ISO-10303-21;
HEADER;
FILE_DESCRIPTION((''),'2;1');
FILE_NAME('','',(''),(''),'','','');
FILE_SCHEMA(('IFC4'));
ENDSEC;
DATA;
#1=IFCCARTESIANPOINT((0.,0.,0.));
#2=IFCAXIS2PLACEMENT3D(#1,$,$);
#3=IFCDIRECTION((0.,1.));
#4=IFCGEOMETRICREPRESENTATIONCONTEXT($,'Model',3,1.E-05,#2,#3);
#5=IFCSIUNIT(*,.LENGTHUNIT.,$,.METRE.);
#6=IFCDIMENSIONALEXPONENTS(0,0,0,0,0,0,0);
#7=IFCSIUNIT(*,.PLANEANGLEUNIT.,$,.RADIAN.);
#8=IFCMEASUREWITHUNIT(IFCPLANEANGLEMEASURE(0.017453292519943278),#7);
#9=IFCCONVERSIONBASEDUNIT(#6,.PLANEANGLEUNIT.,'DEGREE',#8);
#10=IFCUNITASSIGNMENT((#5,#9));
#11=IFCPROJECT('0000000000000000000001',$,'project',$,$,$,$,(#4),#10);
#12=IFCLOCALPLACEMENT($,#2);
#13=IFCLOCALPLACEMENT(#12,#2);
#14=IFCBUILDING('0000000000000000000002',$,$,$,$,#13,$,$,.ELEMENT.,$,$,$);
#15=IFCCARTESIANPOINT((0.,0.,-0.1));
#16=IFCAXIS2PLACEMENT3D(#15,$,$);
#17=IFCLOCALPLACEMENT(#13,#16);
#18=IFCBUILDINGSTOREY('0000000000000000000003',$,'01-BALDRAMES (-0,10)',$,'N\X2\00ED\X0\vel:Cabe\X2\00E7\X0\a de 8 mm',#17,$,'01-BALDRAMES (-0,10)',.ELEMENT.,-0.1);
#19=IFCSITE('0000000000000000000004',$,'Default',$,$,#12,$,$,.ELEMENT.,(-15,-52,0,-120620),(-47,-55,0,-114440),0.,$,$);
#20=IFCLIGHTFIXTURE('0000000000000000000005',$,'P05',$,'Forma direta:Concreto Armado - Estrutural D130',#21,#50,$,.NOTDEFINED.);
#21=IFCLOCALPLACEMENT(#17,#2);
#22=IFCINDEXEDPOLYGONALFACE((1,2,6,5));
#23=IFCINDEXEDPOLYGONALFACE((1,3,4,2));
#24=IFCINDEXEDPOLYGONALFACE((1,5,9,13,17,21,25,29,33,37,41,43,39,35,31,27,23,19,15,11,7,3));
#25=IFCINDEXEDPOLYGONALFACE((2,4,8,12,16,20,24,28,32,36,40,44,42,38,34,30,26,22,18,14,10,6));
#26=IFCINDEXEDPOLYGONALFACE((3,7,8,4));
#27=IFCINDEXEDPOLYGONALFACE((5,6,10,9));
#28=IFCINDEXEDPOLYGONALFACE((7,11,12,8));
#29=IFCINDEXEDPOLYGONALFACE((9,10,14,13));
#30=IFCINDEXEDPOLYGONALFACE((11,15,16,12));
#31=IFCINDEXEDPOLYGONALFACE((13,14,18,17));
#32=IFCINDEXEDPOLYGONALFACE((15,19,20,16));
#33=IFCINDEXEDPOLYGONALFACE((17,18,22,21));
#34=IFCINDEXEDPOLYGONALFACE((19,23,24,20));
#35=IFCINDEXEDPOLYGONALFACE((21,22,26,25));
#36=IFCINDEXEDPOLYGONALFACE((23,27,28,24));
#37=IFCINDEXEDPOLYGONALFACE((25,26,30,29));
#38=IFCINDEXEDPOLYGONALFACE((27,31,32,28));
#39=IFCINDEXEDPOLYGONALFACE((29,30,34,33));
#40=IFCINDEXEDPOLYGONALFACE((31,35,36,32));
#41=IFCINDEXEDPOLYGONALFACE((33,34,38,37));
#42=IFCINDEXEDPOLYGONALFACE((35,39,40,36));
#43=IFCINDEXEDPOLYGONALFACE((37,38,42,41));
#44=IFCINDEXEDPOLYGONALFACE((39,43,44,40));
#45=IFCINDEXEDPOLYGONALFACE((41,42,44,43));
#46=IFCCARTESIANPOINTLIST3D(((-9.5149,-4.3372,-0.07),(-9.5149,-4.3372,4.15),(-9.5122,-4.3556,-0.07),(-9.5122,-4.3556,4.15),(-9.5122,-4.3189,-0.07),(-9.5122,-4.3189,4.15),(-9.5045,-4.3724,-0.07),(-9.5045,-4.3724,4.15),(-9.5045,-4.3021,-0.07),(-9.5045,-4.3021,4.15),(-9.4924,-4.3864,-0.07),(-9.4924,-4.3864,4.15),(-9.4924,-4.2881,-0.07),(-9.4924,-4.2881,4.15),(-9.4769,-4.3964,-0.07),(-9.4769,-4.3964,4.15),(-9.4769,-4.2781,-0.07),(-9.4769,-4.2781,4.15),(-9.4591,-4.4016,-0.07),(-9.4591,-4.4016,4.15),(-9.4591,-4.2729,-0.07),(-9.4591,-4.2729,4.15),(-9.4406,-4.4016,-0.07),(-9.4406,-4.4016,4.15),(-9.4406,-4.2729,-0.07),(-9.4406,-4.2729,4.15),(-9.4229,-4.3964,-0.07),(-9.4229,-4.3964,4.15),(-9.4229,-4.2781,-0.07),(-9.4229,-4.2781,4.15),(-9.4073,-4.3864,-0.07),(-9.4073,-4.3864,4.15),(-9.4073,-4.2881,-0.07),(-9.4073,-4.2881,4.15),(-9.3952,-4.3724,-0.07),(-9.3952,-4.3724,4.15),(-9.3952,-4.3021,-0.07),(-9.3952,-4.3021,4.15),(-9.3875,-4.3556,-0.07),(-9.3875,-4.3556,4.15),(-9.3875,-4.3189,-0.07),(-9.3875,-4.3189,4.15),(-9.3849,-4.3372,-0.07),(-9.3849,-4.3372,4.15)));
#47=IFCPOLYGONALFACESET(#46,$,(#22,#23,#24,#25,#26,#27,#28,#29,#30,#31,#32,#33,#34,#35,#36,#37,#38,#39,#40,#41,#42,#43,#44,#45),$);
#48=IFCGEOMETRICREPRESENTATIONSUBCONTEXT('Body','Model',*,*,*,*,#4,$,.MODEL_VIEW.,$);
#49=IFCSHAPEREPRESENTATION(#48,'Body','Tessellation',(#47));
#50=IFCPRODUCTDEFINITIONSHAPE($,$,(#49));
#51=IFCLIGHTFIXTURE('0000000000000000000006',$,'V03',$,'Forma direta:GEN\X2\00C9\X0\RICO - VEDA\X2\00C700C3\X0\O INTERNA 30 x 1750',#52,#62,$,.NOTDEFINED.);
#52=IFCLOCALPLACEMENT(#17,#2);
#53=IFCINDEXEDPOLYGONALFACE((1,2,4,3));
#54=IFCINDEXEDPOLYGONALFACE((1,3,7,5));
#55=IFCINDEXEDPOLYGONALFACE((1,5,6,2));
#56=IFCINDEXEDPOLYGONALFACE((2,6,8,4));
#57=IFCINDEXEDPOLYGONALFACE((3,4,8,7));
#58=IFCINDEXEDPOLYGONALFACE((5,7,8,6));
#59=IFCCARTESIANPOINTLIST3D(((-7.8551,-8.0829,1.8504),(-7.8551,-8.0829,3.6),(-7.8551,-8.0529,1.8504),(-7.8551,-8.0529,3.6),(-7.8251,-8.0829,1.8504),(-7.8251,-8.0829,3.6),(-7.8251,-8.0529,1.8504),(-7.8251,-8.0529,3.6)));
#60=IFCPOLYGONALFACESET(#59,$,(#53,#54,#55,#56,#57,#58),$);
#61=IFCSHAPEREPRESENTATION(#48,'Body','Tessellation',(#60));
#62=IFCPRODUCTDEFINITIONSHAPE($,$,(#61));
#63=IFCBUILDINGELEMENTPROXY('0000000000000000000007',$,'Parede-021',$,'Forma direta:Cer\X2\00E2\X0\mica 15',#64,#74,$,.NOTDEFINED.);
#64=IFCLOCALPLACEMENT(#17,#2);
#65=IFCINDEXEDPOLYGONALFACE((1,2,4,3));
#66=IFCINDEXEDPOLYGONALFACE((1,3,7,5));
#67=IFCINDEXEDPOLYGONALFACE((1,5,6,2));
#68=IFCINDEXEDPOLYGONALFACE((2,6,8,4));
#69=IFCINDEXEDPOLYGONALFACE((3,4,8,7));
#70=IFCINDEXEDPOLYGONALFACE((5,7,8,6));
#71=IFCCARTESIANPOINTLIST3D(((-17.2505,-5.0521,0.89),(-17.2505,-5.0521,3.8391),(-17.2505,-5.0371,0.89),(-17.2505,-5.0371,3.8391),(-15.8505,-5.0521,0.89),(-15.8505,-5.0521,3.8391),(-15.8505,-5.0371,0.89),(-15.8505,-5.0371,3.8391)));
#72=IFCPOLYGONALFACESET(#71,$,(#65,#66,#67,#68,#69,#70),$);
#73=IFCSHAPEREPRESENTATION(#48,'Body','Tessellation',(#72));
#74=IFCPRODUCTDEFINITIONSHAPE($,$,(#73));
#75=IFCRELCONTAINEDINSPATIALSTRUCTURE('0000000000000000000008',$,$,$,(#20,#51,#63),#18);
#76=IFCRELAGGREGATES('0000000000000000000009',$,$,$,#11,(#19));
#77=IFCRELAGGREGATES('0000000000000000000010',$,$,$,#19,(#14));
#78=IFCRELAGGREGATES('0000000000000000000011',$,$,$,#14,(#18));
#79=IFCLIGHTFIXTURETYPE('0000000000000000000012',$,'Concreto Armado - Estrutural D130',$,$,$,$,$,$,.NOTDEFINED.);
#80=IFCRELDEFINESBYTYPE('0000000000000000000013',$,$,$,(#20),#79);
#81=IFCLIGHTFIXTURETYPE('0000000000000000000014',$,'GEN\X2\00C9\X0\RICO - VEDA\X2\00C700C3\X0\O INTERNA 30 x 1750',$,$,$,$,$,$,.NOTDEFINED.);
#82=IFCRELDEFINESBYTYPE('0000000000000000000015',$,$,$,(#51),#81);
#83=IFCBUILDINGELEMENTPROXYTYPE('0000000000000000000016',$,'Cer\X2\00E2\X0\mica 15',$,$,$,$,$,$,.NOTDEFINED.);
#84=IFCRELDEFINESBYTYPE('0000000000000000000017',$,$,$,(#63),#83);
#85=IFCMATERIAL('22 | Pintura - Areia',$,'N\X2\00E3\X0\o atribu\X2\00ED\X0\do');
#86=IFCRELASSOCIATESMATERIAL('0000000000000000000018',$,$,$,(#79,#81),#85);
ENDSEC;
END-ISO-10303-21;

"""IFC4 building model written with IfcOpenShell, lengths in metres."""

from ifc_helpers import new_model, entity, si_unit, converted_unit, direction, frame, origin, place, context, subcontext, project, spatial, arc, indexed_curve, outline, extrude, material, type_object, element, save


model = new_model("IFC4")

# Units and contexts
model_context = context("Model", 3, precision=1e-05, world=origin(), true_north=direction((0.0, 1.0)))
body_context = subcontext(model_context, "Body", "Model", "MODEL_VIEW")
ifc_project = project(units=[si_unit("LENGTHUNIT", "METRE"), converted_unit("PLANEANGLEUNIT", "DEGREE", entity("IfcPlaneAngleMeasure", 0.017453292519943278), si_unit("PLANEANGLEUNIT", "RADIAN"), dimensions=[0, 0, 0, 0, 0, 0, 0])], contexts=[model_context])

# Site, building, storey
site_placement = place(None, origin())
site = spatial("IfcSite", under=ifc_project, at=site_placement, Name="Default", CompositionType="ELEMENT", RefLatitude=(-15, -52, 0, -120620), RefLongitude=(-47, -55, 0, -114440), RefElevation=0.0)
building_placement = place(site_placement, origin())
building = spatial("IfcBuilding", under=site, at=building_placement, CompositionType="ELEMENT")
storey_placement = place(building_placement, frame((0.0, 0.0, -0.1)))
storey = spatial("IfcBuildingStorey", under=building, at=storey_placement, Name="01-BALDRAMES (-0,10)", ObjectType="Nível:Cabeça de 8 mm", LongName="01-BALDRAMES (-0,10)", CompositionType="ELEMENT", Elevation=-0.1)

# Shared definitions
ifc_material_1 = material(Name="22 | Pintura - Areia", Category="Não atribuído")

# Light fixtures
light_fixture_type_1 = type_object("IfcLightFixtureType", Name="Concreto Armado - Estrutural D130", PredefinedType="NOTDEFINED", material=ifc_material_1)
light_fixture_1_placement = place(storey_placement, origin())
element("IfcLightFixture", 1, at=light_fixture_1_placement, inside=storey, type_object=light_fixture_type_1, Name="P05", ObjectType="Forma direta:Concreto Armado - Estrutural D130", PredefinedType="NOTDEFINED", context=body_context, shape_type="SweptSolid", body=[
    extrude(outline(indexed_curve([(0.065, 0.0), (0.0, 0.065), (-0.065, 0.0), (0.0, -0.065)], segments=[arc(1, 2, 3), arc(3, 4, 1)], self_intersect=False)), frame((-9.4499, -4.3372, -0.07)), (0.0, 0.0, 1.0), 4.22),
])
light_fixture_type_2 = type_object("IfcLightFixtureType", Name="GENÉRICO - VEDAÇÃO INTERNA 30 x 1750", PredefinedType="NOTDEFINED", material=ifc_material_1)
light_fixture_2_placement = place(storey_placement, origin())
element("IfcLightFixture", 2, at=light_fixture_2_placement, inside=storey, type_object=light_fixture_type_2, Name="V03", ObjectType="Forma direta:GENÉRICO - VEDAÇÃO INTERNA 30 x 1750", PredefinedType="NOTDEFINED", context=body_context, shape_type="SweptSolid", body=[
    extrude(outline(indexed_curve([(-0.015, -0.015), (0.015, -0.015), (0.015, 0.015), (-0.015, 0.015), (-0.015, -0.015)], self_intersect=False)), frame((-7.8401, -8.0679, 1.8504)), (0.0, 0.0, 1.0), 1.7496),
])

# Building element proxy
building_element_proxy_type_1 = type_object("IfcBuildingElementProxyType", Name="Cerâmica 15", PredefinedType="NOTDEFINED")
proxy_1_placement = place(storey_placement, origin())
element("IfcBuildingElementProxy", 3, at=proxy_1_placement, inside=storey, type_object=building_element_proxy_type_1, Name="Parede-021", ObjectType="Forma direta:Cerâmica 15", PredefinedType="NOTDEFINED", context=body_context, shape_type="SweptSolid", body=[
    extrude(outline(indexed_curve([(-0.0075, -0.7), (0.0075, -0.7), (0.0075, 0.7), (-0.0075, 0.7), (-0.0075, -0.7)], self_intersect=False)), frame((-16.5505, -5.0446, 0.89), z_axis=(0.0, 0.0, 1.0), x_axis=(-0.000013, -1.0, 0.0)), (0.0, 0.0, 1.0), 2.9491),
])

save(model, "model.ifc")
